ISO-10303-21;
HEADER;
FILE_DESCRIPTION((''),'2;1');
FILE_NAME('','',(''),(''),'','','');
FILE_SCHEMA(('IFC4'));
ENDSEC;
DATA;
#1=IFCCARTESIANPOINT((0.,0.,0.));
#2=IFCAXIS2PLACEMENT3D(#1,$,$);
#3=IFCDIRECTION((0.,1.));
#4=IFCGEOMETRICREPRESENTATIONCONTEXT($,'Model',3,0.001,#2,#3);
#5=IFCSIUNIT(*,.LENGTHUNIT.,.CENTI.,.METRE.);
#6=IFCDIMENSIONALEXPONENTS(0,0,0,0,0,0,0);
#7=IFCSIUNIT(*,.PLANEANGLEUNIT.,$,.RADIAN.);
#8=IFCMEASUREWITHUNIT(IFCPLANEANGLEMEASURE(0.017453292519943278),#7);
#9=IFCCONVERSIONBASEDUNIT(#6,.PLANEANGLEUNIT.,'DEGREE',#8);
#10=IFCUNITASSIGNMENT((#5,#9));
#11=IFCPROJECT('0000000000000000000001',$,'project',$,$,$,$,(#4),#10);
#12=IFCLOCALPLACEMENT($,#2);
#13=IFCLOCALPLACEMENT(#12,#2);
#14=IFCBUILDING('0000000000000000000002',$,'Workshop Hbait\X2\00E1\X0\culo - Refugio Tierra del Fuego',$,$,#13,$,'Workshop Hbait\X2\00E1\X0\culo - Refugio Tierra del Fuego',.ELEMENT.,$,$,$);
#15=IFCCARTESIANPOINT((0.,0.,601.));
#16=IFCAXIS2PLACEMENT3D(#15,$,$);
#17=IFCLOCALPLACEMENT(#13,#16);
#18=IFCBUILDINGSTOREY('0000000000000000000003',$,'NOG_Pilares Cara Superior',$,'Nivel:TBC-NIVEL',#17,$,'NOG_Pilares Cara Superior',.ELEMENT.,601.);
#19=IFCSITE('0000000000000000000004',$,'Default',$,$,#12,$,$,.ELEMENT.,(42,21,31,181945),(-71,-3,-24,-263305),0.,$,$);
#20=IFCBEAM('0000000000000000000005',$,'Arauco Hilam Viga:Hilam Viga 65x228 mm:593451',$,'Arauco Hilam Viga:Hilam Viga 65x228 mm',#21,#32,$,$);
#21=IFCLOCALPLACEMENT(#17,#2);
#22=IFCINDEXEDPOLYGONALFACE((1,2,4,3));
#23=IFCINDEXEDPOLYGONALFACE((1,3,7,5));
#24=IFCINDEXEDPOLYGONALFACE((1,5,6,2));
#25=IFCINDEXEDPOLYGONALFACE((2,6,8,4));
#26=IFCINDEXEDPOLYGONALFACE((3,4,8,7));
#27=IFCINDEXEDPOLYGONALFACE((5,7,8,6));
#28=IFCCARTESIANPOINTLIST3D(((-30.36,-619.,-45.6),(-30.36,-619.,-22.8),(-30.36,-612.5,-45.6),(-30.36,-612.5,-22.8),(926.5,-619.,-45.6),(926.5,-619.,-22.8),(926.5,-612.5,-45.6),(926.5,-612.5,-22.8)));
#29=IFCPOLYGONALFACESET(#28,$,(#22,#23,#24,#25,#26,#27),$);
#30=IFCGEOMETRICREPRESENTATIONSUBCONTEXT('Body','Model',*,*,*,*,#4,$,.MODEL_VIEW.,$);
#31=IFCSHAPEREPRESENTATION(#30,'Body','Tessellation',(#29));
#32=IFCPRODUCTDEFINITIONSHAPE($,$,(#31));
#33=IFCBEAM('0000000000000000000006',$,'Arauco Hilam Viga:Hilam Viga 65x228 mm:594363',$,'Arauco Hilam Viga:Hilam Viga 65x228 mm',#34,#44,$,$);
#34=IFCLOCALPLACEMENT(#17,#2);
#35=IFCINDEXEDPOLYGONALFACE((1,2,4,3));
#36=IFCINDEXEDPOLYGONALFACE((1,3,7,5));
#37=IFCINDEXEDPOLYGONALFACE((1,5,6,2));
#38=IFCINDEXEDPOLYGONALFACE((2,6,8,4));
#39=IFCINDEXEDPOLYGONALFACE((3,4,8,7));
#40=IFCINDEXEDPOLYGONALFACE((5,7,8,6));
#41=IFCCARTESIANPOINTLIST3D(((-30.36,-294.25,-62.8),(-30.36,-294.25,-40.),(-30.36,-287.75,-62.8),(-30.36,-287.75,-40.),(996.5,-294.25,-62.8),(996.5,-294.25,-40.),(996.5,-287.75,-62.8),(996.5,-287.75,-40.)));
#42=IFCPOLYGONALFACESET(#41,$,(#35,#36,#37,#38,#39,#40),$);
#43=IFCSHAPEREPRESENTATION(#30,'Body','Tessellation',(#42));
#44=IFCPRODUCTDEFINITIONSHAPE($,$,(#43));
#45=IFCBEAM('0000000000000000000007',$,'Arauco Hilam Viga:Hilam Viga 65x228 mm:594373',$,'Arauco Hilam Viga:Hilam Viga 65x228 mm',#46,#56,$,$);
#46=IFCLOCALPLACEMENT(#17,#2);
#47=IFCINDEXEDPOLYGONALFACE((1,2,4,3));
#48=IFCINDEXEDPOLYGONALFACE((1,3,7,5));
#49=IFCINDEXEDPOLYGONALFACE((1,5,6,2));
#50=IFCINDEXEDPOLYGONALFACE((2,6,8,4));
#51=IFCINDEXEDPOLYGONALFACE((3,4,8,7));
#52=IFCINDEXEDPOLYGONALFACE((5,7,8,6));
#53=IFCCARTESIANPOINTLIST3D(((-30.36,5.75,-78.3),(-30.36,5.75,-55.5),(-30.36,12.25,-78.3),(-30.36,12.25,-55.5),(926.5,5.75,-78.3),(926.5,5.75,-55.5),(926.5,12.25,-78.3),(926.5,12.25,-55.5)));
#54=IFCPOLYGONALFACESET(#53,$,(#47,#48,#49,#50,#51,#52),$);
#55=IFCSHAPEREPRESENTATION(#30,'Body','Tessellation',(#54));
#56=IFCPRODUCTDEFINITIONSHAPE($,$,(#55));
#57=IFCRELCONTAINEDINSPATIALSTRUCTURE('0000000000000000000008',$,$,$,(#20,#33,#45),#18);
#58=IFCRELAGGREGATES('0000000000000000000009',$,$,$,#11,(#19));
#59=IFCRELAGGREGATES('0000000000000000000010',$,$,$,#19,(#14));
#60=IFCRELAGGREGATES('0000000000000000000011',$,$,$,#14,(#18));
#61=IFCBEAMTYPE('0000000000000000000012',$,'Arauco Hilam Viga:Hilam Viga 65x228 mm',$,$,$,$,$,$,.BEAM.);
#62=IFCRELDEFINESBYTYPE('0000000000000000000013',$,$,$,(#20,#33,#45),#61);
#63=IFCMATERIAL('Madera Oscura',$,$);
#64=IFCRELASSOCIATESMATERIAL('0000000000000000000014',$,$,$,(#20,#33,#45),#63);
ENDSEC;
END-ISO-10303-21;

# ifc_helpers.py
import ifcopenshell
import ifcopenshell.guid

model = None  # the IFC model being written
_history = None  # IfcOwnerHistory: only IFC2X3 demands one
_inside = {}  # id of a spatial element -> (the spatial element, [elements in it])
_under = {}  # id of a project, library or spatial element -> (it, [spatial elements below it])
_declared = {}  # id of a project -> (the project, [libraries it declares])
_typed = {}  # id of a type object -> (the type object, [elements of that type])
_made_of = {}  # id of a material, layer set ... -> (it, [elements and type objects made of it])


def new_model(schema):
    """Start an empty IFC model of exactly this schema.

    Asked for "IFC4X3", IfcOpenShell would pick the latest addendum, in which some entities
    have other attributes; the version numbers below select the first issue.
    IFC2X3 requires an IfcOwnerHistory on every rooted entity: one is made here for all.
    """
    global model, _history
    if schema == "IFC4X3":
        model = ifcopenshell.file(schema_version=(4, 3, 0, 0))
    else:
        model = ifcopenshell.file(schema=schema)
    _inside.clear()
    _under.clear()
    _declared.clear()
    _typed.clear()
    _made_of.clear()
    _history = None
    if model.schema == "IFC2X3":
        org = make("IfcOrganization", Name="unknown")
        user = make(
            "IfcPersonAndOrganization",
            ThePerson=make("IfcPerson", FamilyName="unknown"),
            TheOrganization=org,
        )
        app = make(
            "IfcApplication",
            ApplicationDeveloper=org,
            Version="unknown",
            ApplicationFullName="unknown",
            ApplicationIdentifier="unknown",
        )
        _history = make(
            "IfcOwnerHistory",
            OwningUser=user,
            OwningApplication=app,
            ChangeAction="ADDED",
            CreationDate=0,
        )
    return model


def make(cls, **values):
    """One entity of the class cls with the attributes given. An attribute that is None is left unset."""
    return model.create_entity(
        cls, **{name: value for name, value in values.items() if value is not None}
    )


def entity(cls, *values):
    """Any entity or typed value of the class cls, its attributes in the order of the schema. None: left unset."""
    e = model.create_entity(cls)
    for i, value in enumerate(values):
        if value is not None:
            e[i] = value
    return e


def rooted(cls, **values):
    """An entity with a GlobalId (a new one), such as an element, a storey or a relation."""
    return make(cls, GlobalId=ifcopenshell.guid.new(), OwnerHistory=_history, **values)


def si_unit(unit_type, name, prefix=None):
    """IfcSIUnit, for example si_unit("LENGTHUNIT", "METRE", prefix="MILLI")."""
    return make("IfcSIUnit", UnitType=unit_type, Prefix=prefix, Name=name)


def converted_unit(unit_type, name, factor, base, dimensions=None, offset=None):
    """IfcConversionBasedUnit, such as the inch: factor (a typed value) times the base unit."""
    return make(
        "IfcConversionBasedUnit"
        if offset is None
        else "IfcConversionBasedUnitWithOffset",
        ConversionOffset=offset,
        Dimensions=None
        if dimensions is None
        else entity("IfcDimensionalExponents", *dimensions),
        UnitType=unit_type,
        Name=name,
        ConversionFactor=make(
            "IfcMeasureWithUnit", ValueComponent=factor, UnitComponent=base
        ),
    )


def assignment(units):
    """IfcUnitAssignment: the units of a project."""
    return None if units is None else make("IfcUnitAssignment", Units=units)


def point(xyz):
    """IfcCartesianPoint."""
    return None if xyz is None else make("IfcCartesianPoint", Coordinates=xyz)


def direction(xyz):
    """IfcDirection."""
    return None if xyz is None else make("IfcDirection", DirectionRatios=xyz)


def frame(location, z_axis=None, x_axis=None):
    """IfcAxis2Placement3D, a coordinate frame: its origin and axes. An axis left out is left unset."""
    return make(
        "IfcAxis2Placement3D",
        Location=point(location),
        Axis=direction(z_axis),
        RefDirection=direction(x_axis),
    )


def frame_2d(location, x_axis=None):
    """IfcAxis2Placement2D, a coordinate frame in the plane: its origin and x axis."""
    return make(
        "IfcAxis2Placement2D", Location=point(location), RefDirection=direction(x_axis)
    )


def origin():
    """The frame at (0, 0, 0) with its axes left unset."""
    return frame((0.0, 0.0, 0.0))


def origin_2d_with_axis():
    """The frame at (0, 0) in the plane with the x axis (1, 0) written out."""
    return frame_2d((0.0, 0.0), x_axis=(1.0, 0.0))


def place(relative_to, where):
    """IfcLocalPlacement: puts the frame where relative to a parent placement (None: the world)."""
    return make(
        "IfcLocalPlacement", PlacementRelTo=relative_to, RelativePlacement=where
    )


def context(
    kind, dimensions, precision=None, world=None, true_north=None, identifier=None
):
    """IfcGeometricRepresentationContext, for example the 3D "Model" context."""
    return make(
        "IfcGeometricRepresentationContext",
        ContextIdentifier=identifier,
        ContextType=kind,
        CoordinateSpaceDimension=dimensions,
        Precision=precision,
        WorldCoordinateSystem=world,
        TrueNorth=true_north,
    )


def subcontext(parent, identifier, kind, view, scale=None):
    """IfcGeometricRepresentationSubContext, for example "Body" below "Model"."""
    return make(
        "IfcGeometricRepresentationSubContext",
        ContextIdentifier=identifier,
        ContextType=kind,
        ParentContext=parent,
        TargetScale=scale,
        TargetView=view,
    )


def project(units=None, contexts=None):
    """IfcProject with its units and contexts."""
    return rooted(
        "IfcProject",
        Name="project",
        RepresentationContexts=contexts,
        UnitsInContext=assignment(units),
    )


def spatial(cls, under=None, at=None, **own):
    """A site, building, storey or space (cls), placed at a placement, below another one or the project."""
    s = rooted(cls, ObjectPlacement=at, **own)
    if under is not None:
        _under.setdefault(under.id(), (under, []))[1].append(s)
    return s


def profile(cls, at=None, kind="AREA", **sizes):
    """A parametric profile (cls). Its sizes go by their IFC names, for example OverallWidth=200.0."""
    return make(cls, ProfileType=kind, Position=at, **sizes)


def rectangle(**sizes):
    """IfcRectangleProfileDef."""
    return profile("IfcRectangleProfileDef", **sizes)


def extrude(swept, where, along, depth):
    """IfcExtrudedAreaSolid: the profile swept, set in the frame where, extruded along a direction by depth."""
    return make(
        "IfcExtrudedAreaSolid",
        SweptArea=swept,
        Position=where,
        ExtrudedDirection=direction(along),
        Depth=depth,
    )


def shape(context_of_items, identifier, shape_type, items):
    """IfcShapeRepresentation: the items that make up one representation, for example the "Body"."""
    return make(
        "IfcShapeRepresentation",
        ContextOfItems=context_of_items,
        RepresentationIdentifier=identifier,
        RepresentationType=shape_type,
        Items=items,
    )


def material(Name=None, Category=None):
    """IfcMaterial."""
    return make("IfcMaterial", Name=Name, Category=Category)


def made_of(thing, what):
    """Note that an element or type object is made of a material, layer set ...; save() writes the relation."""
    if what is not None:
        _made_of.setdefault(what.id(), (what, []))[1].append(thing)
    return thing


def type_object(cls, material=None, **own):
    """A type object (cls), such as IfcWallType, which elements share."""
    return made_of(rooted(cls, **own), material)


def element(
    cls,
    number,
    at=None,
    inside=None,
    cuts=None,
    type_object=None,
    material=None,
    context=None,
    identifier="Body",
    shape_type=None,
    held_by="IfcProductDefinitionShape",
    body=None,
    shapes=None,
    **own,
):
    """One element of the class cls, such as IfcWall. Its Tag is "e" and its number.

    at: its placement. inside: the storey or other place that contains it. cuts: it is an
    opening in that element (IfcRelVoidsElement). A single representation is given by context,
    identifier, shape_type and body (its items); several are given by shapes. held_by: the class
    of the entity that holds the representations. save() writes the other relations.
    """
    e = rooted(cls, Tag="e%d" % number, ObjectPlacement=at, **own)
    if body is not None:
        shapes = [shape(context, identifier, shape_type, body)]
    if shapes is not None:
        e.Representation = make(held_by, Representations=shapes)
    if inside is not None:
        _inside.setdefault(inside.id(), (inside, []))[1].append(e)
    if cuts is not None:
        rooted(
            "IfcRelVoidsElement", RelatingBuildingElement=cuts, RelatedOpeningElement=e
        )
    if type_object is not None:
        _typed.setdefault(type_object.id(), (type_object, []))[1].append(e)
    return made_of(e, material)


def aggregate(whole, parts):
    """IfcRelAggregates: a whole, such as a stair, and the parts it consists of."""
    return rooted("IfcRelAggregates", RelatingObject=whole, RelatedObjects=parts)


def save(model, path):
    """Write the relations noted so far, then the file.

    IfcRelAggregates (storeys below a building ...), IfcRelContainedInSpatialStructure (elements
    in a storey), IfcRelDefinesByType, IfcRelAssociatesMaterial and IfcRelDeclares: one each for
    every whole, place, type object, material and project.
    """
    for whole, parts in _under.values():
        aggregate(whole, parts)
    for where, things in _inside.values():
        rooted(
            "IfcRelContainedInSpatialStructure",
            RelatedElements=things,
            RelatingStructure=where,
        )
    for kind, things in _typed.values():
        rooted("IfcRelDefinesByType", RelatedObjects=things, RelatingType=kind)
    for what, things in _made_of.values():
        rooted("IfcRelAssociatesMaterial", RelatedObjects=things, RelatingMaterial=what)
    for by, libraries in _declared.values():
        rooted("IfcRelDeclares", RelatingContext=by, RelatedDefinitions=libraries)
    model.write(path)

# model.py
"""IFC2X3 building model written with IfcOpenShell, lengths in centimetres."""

from ifc_helpers import new_model, entity, si_unit, converted_unit, direction, frame, frame_2d, origin, origin_2d_with_axis, place, context, subcontext, project, spatial, rectangle, extrude, material, type_object, element, save


model = new_model("IFC2X3")

# Units and contexts
model_context = context("Model", 3, precision=0.001, world=origin(), true_north=direction((0.0, 1.0)))
body_context = subcontext(model_context, "Body", "Model", "MODEL_VIEW")
ifc_project = project(units=[si_unit("LENGTHUNIT", "METRE", prefix="CENTI"), converted_unit("PLANEANGLEUNIT", "DEGREE", entity("IfcPlaneAngleMeasure", 0.017453292519943278), si_unit("PLANEANGLEUNIT", "RADIAN"), dimensions=[0, 0, 0, 0, 0, 0, 0])], contexts=[model_context])

# Site, building, storey
site_placement = place(None, origin())
site = spatial("IfcSite", under=ifc_project, at=site_placement, Name="Default", CompositionType="ELEMENT", RefLatitude=(42, 21, 31, 181945), RefLongitude=(-71, -3, -24, -263305), RefElevation=0.0)
building_placement = place(site_placement, origin())
building = spatial("IfcBuilding", under=site, at=building_placement, Name="Workshop Hbaitáculo - Refugio Tierra del Fuego", LongName="Workshop Hbaitáculo - Refugio Tierra del Fuego", CompositionType="ELEMENT")
storey_placement = place(building_placement, frame((0.0, 0.0, 601.0)))
storey = spatial("IfcBuildingStorey", under=building, at=storey_placement, Name="NOG_Pilares Cara Superior", ObjectType="Nivel:TBC-NIVEL", LongName="NOG_Pilares Cara Superior", CompositionType="ELEMENT", Elevation=601.0)

# Beams
ifc_material = material(Name="Madera Oscura")
beam_type = type_object("IfcBeamType", Name="Arauco Hilam Viga:Hilam Viga 65x228 mm", PredefinedType="BEAM")
beam_1_placement = place(storey_placement, frame((-96.14, -615.75, -22.8)))
element("IfcBeam", 1, at=beam_1_placement, inside=storey, type_object=beam_type, material=ifc_material, Name="Arauco Hilam Viga:Hilam Viga 65x228 mm:593451", ObjectType="Arauco Hilam Viga:Hilam Viga 65x228 mm", context=body_context, shape_type="SweptSolid", body=[
    extrude(rectangle(XDim=22.8, YDim=6.5, at=origin_2d_with_axis()), frame((65.78, 0.0, -11.4), z_axis=(1.0, 0.0, 0.0), x_axis=(0.0, 0.0, -1.0)), (0.0, 0.0, 1.0), 956.86),
])
beam_2_placement = place(storey_placement, frame((-96.14, -291.0, -40.0)))
element("IfcBeam", 2, at=beam_2_placement, inside=storey, type_object=beam_type, material=ifc_material, Name="Arauco Hilam Viga:Hilam Viga 65x228 mm:594363", ObjectType="Arauco Hilam Viga:Hilam Viga 65x228 mm", context=body_context, shape_type="SweptSolid", body=[
    extrude(rectangle(XDim=22.8, YDim=6.5, at=frame_2d((0.0, 0.0), x_axis=(1.0, 0.0))), frame((65.78, 0.0, -11.4), z_axis=(1.0, 0.0, 0.0), x_axis=(0.0, 0.0, -1.0)), (0.0, 0.0, 1.0), 1026.86),
])
beam_3_placement = place(storey_placement, frame((-96.14, 9.0, -55.5)))
element("IfcBeam", 3, at=beam_3_placement, inside=storey, type_object=beam_type, material=ifc_material, Name="Arauco Hilam Viga:Hilam Viga 65x228 mm:594373", ObjectType="Arauco Hilam Viga:Hilam Viga 65x228 mm", context=body_context, shape_type="SweptSolid", body=[
    extrude(rectangle(XDim=22.8, YDim=6.5, at=frame_2d((0.0, 0.0), x_axis=(1.0, 0.0))), frame((65.78, 0.0, -11.4), z_axis=(1.0, 0.0, 0.0), x_axis=(0.0, 0.0, -1.0)), (0.0, 0.0, 1.0), 956.86),
])

save(model, "model.ifc")
